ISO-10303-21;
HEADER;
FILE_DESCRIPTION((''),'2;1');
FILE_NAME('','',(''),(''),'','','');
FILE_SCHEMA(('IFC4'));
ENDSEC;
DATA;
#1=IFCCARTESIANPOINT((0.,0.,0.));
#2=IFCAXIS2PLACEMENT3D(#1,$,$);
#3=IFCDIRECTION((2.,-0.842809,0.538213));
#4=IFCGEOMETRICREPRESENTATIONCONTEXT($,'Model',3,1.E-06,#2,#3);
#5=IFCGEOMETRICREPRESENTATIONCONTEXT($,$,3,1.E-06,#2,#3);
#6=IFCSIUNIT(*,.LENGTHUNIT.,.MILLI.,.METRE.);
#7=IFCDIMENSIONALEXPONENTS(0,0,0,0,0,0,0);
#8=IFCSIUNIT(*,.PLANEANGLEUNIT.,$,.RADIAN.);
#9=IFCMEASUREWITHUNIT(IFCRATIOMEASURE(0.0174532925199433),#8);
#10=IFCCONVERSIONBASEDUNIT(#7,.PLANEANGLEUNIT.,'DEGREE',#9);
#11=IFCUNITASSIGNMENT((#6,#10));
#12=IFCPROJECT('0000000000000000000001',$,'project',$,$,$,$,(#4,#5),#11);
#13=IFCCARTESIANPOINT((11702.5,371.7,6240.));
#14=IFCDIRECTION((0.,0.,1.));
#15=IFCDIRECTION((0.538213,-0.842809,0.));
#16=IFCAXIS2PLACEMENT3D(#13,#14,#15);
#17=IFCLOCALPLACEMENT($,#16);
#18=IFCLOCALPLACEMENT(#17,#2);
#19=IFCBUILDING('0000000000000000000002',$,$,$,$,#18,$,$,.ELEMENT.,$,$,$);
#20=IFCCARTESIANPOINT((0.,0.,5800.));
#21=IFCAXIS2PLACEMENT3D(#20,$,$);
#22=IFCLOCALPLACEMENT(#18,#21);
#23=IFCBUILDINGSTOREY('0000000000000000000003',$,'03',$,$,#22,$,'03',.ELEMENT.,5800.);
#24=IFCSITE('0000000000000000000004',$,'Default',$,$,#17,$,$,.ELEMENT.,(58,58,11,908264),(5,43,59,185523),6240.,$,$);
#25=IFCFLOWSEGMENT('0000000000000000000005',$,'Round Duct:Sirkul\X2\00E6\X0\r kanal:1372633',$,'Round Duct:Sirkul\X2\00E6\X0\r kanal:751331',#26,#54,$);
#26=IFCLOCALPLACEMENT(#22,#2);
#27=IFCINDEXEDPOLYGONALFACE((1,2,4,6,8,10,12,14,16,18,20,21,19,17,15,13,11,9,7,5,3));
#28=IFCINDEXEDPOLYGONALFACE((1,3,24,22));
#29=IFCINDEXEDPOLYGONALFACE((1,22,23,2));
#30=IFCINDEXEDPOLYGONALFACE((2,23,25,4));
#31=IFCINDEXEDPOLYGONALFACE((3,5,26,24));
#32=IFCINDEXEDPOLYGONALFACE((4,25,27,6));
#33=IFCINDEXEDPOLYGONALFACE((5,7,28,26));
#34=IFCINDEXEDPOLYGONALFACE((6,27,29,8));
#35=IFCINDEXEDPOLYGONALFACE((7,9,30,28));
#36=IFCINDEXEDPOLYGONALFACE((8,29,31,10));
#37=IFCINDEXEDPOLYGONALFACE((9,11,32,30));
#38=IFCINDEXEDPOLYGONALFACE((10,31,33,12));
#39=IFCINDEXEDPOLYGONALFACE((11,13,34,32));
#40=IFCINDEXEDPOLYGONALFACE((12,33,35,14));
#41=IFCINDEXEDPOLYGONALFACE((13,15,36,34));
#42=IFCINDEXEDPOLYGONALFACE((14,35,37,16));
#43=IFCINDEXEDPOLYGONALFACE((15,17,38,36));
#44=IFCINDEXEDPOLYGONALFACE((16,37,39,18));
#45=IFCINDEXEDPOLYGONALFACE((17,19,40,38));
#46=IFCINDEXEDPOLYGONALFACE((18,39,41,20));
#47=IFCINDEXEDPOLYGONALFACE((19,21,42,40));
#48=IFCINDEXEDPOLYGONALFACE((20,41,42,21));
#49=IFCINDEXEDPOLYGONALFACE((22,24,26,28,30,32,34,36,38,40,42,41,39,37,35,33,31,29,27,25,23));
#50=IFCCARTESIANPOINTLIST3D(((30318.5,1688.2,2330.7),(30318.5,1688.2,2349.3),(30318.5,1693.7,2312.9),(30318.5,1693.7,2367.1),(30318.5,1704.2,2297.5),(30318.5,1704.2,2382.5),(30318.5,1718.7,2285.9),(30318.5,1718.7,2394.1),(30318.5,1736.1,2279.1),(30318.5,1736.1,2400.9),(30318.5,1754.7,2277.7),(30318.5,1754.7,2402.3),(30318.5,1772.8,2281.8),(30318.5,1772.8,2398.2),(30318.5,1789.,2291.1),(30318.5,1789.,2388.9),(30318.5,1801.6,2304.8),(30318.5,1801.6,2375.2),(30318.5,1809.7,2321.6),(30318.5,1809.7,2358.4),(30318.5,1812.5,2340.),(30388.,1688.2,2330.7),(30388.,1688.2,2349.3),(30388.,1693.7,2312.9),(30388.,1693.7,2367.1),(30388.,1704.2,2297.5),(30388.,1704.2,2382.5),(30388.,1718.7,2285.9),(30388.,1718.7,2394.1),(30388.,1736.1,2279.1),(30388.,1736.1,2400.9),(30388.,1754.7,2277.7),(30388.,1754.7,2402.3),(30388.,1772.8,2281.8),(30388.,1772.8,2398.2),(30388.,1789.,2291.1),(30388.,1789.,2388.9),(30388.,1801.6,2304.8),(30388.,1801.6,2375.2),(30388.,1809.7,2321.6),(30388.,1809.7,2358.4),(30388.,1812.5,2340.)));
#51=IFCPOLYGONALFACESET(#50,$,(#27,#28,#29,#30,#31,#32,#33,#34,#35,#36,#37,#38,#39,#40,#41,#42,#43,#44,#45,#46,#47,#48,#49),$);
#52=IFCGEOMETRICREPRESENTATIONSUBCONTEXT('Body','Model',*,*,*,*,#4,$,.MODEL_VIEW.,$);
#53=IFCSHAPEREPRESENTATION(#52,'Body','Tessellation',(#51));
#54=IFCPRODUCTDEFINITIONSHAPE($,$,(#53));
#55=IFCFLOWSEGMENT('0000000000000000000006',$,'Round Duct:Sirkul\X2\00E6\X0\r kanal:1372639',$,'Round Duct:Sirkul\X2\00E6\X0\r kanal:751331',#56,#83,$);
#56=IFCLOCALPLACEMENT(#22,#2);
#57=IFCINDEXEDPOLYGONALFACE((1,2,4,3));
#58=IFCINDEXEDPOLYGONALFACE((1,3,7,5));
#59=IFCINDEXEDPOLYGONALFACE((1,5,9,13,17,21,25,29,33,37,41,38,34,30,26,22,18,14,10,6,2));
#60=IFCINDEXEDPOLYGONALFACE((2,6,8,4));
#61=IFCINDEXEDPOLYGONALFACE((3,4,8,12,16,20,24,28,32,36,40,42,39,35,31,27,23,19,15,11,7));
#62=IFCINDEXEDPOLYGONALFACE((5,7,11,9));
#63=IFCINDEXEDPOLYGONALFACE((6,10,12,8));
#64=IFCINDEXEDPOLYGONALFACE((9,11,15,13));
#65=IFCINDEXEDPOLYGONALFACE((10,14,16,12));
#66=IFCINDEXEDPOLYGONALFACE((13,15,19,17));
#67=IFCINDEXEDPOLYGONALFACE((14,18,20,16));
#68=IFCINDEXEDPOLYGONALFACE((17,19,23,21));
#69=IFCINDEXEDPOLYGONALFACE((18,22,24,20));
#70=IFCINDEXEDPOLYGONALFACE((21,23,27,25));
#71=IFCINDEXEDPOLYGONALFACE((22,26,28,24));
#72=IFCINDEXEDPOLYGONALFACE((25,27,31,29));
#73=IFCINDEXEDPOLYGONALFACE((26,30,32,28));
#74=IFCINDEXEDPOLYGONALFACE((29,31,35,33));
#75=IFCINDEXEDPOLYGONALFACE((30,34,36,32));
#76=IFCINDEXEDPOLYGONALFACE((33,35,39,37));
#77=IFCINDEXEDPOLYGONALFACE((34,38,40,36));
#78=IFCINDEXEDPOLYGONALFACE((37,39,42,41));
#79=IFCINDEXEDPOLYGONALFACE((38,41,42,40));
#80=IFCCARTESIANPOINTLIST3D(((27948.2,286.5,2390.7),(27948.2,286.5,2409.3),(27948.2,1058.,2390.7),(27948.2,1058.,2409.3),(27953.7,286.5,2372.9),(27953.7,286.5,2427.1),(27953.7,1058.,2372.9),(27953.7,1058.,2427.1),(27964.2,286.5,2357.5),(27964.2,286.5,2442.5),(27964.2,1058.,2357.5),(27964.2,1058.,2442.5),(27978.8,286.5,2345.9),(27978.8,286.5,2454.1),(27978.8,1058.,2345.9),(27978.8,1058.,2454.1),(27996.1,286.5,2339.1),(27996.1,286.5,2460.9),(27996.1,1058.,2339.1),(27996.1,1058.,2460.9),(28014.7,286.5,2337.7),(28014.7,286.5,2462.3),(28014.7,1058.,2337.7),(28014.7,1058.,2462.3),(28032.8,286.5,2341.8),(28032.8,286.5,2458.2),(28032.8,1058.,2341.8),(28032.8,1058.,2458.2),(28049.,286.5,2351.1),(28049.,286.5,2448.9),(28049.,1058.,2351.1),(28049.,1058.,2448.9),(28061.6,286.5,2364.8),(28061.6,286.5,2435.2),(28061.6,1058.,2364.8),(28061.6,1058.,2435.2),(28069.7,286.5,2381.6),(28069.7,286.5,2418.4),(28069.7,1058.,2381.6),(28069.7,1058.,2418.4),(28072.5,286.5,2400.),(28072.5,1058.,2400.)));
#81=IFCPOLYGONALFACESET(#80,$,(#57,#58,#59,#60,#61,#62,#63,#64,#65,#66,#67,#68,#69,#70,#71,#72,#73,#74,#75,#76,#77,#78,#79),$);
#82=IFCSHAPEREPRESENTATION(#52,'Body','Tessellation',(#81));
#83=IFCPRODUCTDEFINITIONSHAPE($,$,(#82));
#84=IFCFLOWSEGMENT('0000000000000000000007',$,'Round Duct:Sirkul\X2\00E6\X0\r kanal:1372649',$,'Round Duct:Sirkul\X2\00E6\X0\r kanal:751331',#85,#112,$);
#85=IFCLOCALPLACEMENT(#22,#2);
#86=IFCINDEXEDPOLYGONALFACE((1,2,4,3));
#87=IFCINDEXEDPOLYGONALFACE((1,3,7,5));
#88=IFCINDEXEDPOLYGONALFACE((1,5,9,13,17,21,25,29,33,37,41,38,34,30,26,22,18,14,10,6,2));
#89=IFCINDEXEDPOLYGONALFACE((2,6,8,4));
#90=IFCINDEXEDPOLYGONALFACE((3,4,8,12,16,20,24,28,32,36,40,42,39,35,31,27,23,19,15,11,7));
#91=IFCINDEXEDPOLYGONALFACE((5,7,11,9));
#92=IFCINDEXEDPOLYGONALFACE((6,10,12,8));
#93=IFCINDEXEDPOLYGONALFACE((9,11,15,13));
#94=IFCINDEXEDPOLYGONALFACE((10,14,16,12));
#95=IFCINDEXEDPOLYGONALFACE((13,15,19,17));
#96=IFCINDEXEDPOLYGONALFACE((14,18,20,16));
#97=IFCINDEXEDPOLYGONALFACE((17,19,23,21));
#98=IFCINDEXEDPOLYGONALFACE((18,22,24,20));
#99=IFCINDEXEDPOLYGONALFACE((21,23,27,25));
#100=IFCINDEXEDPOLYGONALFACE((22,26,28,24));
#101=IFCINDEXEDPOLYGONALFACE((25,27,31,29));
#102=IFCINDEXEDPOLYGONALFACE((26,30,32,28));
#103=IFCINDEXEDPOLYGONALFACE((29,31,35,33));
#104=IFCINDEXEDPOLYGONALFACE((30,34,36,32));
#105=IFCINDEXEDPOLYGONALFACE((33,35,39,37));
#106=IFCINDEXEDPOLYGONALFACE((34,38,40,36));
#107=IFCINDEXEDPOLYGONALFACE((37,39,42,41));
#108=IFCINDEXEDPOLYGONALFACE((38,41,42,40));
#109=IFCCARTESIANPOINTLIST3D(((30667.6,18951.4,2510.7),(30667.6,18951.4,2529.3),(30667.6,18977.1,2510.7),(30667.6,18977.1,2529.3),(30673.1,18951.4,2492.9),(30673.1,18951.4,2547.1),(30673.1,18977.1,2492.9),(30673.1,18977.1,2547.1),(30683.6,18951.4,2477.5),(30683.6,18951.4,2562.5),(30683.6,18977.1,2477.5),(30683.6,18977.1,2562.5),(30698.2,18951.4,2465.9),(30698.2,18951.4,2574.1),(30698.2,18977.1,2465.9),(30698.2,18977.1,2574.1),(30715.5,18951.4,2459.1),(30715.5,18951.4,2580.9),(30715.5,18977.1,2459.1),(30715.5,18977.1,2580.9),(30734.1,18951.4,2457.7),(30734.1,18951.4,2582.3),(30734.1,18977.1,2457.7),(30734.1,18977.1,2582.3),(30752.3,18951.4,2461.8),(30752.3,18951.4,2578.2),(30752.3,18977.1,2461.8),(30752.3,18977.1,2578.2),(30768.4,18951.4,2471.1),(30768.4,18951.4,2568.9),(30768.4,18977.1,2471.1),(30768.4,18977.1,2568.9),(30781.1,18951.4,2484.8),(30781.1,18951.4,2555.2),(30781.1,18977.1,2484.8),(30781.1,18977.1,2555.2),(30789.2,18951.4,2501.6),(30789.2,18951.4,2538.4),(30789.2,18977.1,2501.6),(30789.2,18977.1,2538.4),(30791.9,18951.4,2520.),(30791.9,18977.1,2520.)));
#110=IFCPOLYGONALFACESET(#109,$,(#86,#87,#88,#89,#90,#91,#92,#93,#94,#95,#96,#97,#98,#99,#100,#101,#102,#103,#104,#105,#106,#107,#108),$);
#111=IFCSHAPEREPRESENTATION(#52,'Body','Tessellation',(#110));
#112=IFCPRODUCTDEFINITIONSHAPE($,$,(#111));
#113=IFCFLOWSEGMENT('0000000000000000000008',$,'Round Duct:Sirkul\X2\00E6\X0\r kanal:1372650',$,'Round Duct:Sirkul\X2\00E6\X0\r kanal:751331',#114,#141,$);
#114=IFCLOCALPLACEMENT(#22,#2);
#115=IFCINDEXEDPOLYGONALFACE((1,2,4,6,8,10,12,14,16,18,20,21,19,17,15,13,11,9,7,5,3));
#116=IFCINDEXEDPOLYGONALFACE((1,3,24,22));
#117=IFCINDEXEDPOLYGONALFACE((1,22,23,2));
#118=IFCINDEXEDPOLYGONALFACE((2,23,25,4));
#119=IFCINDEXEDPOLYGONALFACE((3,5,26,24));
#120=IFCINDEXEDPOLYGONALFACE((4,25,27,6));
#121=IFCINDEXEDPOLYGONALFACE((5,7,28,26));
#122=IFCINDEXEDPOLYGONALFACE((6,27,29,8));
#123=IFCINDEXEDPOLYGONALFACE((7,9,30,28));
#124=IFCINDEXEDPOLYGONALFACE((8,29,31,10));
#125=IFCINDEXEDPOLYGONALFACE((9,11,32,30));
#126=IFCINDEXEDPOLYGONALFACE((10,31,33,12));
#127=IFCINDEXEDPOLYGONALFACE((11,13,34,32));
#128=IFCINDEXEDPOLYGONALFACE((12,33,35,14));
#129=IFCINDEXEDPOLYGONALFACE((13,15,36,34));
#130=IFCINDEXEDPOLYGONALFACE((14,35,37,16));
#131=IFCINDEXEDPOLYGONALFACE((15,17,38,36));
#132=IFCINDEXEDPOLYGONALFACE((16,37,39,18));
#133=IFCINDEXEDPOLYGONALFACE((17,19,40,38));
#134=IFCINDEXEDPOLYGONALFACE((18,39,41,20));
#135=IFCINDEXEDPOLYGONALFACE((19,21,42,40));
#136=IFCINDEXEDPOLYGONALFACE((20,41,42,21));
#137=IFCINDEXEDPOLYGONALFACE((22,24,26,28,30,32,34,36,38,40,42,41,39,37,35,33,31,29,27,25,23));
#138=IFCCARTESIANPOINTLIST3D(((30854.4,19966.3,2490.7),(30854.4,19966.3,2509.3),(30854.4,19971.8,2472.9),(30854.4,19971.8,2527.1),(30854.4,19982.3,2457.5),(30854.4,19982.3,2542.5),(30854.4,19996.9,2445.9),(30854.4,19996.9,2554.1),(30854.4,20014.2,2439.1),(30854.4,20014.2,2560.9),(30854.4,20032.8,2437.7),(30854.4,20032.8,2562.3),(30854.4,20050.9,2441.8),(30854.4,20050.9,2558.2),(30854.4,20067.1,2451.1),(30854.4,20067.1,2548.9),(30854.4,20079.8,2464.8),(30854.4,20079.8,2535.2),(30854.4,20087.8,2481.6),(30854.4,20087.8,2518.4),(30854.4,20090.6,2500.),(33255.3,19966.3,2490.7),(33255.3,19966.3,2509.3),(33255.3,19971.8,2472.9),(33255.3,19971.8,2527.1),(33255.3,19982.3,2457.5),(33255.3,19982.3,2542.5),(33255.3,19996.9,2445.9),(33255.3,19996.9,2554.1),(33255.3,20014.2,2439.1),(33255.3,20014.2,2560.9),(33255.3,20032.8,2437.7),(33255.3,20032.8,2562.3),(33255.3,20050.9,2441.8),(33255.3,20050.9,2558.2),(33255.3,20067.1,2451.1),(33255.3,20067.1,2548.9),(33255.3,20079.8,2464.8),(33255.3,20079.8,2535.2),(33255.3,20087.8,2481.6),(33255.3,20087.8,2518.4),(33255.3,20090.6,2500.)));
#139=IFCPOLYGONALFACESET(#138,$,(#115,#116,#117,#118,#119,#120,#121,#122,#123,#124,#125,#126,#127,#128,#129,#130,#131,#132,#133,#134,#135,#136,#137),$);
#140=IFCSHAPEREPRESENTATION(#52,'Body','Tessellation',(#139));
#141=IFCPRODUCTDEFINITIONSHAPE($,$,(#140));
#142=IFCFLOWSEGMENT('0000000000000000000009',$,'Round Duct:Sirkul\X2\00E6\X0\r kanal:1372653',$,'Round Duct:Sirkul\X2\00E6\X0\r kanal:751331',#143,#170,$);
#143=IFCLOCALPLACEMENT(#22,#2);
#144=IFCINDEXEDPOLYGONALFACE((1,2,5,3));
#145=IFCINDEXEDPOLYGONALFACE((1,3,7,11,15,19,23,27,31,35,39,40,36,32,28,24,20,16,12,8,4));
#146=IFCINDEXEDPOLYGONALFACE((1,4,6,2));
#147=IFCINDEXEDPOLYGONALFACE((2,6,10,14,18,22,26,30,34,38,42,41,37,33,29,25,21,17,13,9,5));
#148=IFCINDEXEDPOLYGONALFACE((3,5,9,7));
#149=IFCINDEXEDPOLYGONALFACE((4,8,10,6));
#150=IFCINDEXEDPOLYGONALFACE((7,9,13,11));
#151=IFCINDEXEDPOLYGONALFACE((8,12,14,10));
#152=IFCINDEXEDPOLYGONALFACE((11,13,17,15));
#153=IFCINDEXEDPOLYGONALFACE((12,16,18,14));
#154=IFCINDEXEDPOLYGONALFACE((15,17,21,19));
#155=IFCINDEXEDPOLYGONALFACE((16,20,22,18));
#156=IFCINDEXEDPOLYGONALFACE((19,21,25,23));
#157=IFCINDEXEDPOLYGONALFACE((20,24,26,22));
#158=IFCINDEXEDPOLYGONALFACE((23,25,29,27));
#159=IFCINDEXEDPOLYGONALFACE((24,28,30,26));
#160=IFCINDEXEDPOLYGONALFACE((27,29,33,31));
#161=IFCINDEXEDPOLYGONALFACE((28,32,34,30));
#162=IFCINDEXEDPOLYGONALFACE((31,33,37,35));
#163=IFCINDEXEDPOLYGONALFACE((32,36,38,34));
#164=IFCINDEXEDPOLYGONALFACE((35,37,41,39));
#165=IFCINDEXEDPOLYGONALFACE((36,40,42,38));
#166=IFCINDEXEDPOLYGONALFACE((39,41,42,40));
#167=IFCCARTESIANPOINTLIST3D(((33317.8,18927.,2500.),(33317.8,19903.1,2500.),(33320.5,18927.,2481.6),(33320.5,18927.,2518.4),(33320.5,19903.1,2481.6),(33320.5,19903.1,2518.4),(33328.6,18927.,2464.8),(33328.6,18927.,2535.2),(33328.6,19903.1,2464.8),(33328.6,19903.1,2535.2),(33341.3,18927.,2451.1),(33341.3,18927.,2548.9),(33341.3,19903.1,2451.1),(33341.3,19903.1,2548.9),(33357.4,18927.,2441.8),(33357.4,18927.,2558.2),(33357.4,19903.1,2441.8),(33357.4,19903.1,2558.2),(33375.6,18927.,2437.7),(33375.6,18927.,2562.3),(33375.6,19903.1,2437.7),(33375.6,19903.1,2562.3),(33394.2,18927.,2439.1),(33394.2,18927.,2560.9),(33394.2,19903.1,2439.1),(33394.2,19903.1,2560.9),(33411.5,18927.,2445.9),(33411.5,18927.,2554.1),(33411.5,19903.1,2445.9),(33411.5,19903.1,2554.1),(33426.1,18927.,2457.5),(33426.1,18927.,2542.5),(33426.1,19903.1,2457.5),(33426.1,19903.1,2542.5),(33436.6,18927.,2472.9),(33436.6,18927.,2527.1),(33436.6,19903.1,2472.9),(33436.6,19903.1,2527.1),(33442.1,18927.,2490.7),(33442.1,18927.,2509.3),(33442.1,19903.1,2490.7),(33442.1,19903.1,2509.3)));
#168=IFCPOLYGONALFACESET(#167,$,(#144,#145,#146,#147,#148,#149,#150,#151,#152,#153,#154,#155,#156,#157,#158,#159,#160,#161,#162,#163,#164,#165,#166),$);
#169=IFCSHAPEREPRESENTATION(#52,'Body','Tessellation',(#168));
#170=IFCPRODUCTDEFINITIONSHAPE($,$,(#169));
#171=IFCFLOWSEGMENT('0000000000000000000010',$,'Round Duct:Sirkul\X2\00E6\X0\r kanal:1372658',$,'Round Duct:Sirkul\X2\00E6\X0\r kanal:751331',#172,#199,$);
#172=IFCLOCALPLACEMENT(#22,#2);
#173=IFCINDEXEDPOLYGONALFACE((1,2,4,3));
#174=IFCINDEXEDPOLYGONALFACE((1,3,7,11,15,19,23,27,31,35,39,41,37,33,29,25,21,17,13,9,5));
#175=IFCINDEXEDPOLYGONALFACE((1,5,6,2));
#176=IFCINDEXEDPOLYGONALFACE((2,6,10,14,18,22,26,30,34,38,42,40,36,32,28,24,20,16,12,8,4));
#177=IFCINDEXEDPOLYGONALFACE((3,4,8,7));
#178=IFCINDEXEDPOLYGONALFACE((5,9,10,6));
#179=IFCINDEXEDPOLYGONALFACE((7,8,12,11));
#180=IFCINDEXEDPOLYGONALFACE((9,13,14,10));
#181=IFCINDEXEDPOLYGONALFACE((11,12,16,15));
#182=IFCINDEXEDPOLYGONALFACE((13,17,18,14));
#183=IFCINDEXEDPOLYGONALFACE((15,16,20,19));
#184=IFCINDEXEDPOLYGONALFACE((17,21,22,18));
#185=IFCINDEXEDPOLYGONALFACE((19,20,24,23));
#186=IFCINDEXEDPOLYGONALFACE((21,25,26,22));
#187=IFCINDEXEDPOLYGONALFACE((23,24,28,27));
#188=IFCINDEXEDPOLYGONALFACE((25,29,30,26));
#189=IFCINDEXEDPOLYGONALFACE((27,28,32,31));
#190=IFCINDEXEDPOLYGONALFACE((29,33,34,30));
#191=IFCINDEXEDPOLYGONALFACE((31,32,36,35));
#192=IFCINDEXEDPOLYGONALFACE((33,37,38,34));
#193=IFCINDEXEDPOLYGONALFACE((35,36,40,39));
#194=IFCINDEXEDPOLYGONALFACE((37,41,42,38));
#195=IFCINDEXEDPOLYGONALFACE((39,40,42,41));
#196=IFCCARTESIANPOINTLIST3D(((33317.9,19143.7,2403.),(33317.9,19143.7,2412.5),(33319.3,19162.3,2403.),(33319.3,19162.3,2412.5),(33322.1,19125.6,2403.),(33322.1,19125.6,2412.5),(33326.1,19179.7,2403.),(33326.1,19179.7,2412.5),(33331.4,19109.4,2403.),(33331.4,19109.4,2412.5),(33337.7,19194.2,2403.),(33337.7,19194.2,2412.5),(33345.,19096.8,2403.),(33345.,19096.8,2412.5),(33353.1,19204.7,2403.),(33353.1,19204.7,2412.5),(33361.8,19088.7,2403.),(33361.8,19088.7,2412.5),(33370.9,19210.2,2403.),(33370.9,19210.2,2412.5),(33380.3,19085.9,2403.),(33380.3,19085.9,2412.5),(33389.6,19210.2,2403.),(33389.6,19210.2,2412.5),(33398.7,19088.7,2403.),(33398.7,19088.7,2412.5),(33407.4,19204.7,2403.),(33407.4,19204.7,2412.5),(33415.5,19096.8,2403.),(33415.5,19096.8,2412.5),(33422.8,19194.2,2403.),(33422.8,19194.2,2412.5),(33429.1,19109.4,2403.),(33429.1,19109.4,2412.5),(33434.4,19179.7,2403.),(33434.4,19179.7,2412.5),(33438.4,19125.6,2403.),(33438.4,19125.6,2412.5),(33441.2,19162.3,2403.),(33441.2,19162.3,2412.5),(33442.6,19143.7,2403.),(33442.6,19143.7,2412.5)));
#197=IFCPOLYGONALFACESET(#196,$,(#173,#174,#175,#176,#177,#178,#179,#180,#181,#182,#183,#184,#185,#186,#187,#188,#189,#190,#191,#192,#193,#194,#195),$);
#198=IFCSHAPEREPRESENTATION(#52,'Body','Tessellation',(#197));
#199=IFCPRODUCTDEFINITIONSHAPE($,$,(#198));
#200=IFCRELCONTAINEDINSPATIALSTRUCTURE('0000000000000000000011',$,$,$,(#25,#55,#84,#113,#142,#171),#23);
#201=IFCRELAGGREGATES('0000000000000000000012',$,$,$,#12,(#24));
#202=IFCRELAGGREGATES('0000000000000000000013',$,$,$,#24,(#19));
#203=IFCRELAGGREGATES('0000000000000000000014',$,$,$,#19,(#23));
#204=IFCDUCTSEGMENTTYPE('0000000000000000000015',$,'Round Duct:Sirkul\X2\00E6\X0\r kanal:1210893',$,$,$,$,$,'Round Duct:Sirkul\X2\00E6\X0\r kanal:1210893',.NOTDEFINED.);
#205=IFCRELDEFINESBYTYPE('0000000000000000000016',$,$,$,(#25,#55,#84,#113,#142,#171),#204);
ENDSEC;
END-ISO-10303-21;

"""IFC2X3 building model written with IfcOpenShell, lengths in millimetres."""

from ifc_helpers import new_model, entity, si_unit, converted_unit, direction, frame, frame_2d, origin, origin_2d_with_axis, place, context, subcontext, project, spatial, circle, extrude, type_object, element, save


model = new_model("IFC2X3")

# Units and contexts
model_context = context("Model", 3, precision=1e-06, world=origin(), true_north=direction((2.0, -0.842809, 0.538213)))
context_of_model = context(None, 3, precision=1e-06, world=origin(), true_north=direction((2.0, -0.842809, 0.538213)))
body_context = subcontext(model_context, "Body", "Model", "MODEL_VIEW")
ifc_project = project(units=[si_unit("LENGTHUNIT", "METRE", prefix="MILLI"), converted_unit("PLANEANGLEUNIT", "DEGREE", entity("IfcRatioMeasure", 0.0174532925199433), si_unit("PLANEANGLEUNIT", "RADIAN"), dimensions=[0, 0, 0, 0, 0, 0, 0])], contexts=[model_context, context_of_model])

# Site, building, storey
site_placement = place(None, frame((11702.5, 371.7, 6240.0), z_axis=(0.0, 0.0, 1.0), x_axis=(0.538213, -0.842809, 0.0)))
site = spatial("IfcSite", under=ifc_project, at=site_placement, Name="Default", CompositionType="ELEMENT", RefLatitude=(58, 58, 11, 908264), RefLongitude=(5, 43, 59, 185523), RefElevation=6240.0)
building_placement = place(site_placement, origin())
building = spatial("IfcBuilding", under=site, at=building_placement, CompositionType="ELEMENT")
storey_placement = place(building_placement, frame((0.0, 0.0, 5800.0)))
storey = spatial("IfcBuildingStorey", under=building, at=storey_placement, Name="03", LongName="03", CompositionType="ELEMENT", Elevation=5800.0)

# Flow segments
duct_segment_type_1 = type_object("IfcDuctSegmentType", Name="Round Duct:Sirkulær kanal:1210893", ElementType="Round Duct:Sirkulær kanal:1210893", PredefinedType="NOTDEFINED")
flow_segment_1_placement = place(storey_placement, origin())
element("IfcFlowSegment", 1, at=flow_segment_1_placement, inside=storey, type_object=duct_segment_type_1, Name="Round Duct:Sirkulær kanal:1372633", ObjectType="Round Duct:Sirkulær kanal:751331", context=body_context, shape_type="SweptSolid", body=[
    extrude(circle(Radius=62.5, at=frame_2d((0.0, 0.0), x_axis=(1.0, 0.0))), frame((30318.5, 1750.0, 2340.0), z_axis=(1.0, 0.0, 0.0), x_axis=(0.0, 1.0, 0.0)), (0.0, 0.0, 1.0), 69.5),
])
flow_segment_2_placement = place(storey_placement, origin())
element("IfcFlowSegment", 2, at=flow_segment_2_placement, inside=storey, type_object=duct_segment_type_1, Name="Round Duct:Sirkulær kanal:1372639", ObjectType="Round Duct:Sirkulær kanal:751331", context=body_context, shape_type="SweptSolid", body=[
    extrude(circle(Radius=62.5, at=origin_2d_with_axis()), frame((28010.0, 286.5, 2400.0), z_axis=(0.0, 1.0, 0.0), x_axis=(1.0, 0.0, 0.0)), (0.0, 0.0, 1.0), 771.5),
])
flow_segment_3_placement = place(storey_placement, origin())
element("IfcFlowSegment", 3, at=flow_segment_3_placement, inside=storey, type_object=duct_segment_type_1, Name="Round Duct:Sirkulær kanal:1372649", ObjectType="Round Duct:Sirkulær kanal:751331", context=body_context, shape_type="SweptSolid", body=[
    extrude(circle(Radius=62.5, at=origin_2d_with_axis()), frame((30729.4, 18951.4, 2520.0), z_axis=(0.0, 1.0, 0.0), x_axis=(1.0, 0.0, 0.0)), (0.0, 0.0, 1.0), 25.7),
])
flow_segment_4_placement = place(storey_placement, origin())
element("IfcFlowSegment", 4, at=flow_segment_4_placement, inside=storey, type_object=duct_segment_type_1, Name="Round Duct:Sirkulær kanal:1372650", ObjectType="Round Duct:Sirkulær kanal:751331", context=body_context, shape_type="SweptSolid", body=[
    extrude(circle(Radius=62.5, at=frame_2d((0.0, 0.0), x_axis=(1.0, 0.0))), frame((30854.4, 20028.1, 2500.0), z_axis=(1.0, 0.0, 0.0), x_axis=(0.0, 1.0, 0.0)), (0.0, 0.0, 1.0), 2400.8),
])
flow_segment_5_placement = place(storey_placement, origin())
element("IfcFlowSegment", 5, at=flow_segment_5_placement, inside=storey, type_object=duct_segment_type_1, Name="Round Duct:Sirkulær kanal:1372653", ObjectType="Round Duct:Sirkulær kanal:751331", context=body_context, shape_type="SweptSolid", body=[
    extrude(circle(Radius=62.5, at=frame_2d((0.0, 0.0), x_axis=(1.0, 0.0))), frame((33380.3, 18927.0, 2500.0), z_axis=(0.0, 1.0, 0.0), x_axis=(-1.0, 0.0, 0.0)), (0.0, 0.0, 1.0), 976.1),
])
flow_segment_6_placement = place(storey_placement, origin())
element("IfcFlowSegment", 6, at=flow_segment_6_placement, inside=storey, type_object=duct_segment_type_1, Name="Round Duct:Sirkulær kanal:1372658", ObjectType="Round Duct:Sirkulær kanal:751331", context=body_context, shape_type="SweptSolid", body=[
    extrude(circle(Radius=62.5, at=frame_2d((0.0, 0.0), x_axis=(1.0, 0.0))), frame((33380.3, 19148.4, 2403.0), z_axis=(0.0, 0.0, 1.0), x_axis=(0.0, -1.0, 0.0)), (0.0, 0.0, 1.0), 9.5),
])

save(model, "model.ifc")
